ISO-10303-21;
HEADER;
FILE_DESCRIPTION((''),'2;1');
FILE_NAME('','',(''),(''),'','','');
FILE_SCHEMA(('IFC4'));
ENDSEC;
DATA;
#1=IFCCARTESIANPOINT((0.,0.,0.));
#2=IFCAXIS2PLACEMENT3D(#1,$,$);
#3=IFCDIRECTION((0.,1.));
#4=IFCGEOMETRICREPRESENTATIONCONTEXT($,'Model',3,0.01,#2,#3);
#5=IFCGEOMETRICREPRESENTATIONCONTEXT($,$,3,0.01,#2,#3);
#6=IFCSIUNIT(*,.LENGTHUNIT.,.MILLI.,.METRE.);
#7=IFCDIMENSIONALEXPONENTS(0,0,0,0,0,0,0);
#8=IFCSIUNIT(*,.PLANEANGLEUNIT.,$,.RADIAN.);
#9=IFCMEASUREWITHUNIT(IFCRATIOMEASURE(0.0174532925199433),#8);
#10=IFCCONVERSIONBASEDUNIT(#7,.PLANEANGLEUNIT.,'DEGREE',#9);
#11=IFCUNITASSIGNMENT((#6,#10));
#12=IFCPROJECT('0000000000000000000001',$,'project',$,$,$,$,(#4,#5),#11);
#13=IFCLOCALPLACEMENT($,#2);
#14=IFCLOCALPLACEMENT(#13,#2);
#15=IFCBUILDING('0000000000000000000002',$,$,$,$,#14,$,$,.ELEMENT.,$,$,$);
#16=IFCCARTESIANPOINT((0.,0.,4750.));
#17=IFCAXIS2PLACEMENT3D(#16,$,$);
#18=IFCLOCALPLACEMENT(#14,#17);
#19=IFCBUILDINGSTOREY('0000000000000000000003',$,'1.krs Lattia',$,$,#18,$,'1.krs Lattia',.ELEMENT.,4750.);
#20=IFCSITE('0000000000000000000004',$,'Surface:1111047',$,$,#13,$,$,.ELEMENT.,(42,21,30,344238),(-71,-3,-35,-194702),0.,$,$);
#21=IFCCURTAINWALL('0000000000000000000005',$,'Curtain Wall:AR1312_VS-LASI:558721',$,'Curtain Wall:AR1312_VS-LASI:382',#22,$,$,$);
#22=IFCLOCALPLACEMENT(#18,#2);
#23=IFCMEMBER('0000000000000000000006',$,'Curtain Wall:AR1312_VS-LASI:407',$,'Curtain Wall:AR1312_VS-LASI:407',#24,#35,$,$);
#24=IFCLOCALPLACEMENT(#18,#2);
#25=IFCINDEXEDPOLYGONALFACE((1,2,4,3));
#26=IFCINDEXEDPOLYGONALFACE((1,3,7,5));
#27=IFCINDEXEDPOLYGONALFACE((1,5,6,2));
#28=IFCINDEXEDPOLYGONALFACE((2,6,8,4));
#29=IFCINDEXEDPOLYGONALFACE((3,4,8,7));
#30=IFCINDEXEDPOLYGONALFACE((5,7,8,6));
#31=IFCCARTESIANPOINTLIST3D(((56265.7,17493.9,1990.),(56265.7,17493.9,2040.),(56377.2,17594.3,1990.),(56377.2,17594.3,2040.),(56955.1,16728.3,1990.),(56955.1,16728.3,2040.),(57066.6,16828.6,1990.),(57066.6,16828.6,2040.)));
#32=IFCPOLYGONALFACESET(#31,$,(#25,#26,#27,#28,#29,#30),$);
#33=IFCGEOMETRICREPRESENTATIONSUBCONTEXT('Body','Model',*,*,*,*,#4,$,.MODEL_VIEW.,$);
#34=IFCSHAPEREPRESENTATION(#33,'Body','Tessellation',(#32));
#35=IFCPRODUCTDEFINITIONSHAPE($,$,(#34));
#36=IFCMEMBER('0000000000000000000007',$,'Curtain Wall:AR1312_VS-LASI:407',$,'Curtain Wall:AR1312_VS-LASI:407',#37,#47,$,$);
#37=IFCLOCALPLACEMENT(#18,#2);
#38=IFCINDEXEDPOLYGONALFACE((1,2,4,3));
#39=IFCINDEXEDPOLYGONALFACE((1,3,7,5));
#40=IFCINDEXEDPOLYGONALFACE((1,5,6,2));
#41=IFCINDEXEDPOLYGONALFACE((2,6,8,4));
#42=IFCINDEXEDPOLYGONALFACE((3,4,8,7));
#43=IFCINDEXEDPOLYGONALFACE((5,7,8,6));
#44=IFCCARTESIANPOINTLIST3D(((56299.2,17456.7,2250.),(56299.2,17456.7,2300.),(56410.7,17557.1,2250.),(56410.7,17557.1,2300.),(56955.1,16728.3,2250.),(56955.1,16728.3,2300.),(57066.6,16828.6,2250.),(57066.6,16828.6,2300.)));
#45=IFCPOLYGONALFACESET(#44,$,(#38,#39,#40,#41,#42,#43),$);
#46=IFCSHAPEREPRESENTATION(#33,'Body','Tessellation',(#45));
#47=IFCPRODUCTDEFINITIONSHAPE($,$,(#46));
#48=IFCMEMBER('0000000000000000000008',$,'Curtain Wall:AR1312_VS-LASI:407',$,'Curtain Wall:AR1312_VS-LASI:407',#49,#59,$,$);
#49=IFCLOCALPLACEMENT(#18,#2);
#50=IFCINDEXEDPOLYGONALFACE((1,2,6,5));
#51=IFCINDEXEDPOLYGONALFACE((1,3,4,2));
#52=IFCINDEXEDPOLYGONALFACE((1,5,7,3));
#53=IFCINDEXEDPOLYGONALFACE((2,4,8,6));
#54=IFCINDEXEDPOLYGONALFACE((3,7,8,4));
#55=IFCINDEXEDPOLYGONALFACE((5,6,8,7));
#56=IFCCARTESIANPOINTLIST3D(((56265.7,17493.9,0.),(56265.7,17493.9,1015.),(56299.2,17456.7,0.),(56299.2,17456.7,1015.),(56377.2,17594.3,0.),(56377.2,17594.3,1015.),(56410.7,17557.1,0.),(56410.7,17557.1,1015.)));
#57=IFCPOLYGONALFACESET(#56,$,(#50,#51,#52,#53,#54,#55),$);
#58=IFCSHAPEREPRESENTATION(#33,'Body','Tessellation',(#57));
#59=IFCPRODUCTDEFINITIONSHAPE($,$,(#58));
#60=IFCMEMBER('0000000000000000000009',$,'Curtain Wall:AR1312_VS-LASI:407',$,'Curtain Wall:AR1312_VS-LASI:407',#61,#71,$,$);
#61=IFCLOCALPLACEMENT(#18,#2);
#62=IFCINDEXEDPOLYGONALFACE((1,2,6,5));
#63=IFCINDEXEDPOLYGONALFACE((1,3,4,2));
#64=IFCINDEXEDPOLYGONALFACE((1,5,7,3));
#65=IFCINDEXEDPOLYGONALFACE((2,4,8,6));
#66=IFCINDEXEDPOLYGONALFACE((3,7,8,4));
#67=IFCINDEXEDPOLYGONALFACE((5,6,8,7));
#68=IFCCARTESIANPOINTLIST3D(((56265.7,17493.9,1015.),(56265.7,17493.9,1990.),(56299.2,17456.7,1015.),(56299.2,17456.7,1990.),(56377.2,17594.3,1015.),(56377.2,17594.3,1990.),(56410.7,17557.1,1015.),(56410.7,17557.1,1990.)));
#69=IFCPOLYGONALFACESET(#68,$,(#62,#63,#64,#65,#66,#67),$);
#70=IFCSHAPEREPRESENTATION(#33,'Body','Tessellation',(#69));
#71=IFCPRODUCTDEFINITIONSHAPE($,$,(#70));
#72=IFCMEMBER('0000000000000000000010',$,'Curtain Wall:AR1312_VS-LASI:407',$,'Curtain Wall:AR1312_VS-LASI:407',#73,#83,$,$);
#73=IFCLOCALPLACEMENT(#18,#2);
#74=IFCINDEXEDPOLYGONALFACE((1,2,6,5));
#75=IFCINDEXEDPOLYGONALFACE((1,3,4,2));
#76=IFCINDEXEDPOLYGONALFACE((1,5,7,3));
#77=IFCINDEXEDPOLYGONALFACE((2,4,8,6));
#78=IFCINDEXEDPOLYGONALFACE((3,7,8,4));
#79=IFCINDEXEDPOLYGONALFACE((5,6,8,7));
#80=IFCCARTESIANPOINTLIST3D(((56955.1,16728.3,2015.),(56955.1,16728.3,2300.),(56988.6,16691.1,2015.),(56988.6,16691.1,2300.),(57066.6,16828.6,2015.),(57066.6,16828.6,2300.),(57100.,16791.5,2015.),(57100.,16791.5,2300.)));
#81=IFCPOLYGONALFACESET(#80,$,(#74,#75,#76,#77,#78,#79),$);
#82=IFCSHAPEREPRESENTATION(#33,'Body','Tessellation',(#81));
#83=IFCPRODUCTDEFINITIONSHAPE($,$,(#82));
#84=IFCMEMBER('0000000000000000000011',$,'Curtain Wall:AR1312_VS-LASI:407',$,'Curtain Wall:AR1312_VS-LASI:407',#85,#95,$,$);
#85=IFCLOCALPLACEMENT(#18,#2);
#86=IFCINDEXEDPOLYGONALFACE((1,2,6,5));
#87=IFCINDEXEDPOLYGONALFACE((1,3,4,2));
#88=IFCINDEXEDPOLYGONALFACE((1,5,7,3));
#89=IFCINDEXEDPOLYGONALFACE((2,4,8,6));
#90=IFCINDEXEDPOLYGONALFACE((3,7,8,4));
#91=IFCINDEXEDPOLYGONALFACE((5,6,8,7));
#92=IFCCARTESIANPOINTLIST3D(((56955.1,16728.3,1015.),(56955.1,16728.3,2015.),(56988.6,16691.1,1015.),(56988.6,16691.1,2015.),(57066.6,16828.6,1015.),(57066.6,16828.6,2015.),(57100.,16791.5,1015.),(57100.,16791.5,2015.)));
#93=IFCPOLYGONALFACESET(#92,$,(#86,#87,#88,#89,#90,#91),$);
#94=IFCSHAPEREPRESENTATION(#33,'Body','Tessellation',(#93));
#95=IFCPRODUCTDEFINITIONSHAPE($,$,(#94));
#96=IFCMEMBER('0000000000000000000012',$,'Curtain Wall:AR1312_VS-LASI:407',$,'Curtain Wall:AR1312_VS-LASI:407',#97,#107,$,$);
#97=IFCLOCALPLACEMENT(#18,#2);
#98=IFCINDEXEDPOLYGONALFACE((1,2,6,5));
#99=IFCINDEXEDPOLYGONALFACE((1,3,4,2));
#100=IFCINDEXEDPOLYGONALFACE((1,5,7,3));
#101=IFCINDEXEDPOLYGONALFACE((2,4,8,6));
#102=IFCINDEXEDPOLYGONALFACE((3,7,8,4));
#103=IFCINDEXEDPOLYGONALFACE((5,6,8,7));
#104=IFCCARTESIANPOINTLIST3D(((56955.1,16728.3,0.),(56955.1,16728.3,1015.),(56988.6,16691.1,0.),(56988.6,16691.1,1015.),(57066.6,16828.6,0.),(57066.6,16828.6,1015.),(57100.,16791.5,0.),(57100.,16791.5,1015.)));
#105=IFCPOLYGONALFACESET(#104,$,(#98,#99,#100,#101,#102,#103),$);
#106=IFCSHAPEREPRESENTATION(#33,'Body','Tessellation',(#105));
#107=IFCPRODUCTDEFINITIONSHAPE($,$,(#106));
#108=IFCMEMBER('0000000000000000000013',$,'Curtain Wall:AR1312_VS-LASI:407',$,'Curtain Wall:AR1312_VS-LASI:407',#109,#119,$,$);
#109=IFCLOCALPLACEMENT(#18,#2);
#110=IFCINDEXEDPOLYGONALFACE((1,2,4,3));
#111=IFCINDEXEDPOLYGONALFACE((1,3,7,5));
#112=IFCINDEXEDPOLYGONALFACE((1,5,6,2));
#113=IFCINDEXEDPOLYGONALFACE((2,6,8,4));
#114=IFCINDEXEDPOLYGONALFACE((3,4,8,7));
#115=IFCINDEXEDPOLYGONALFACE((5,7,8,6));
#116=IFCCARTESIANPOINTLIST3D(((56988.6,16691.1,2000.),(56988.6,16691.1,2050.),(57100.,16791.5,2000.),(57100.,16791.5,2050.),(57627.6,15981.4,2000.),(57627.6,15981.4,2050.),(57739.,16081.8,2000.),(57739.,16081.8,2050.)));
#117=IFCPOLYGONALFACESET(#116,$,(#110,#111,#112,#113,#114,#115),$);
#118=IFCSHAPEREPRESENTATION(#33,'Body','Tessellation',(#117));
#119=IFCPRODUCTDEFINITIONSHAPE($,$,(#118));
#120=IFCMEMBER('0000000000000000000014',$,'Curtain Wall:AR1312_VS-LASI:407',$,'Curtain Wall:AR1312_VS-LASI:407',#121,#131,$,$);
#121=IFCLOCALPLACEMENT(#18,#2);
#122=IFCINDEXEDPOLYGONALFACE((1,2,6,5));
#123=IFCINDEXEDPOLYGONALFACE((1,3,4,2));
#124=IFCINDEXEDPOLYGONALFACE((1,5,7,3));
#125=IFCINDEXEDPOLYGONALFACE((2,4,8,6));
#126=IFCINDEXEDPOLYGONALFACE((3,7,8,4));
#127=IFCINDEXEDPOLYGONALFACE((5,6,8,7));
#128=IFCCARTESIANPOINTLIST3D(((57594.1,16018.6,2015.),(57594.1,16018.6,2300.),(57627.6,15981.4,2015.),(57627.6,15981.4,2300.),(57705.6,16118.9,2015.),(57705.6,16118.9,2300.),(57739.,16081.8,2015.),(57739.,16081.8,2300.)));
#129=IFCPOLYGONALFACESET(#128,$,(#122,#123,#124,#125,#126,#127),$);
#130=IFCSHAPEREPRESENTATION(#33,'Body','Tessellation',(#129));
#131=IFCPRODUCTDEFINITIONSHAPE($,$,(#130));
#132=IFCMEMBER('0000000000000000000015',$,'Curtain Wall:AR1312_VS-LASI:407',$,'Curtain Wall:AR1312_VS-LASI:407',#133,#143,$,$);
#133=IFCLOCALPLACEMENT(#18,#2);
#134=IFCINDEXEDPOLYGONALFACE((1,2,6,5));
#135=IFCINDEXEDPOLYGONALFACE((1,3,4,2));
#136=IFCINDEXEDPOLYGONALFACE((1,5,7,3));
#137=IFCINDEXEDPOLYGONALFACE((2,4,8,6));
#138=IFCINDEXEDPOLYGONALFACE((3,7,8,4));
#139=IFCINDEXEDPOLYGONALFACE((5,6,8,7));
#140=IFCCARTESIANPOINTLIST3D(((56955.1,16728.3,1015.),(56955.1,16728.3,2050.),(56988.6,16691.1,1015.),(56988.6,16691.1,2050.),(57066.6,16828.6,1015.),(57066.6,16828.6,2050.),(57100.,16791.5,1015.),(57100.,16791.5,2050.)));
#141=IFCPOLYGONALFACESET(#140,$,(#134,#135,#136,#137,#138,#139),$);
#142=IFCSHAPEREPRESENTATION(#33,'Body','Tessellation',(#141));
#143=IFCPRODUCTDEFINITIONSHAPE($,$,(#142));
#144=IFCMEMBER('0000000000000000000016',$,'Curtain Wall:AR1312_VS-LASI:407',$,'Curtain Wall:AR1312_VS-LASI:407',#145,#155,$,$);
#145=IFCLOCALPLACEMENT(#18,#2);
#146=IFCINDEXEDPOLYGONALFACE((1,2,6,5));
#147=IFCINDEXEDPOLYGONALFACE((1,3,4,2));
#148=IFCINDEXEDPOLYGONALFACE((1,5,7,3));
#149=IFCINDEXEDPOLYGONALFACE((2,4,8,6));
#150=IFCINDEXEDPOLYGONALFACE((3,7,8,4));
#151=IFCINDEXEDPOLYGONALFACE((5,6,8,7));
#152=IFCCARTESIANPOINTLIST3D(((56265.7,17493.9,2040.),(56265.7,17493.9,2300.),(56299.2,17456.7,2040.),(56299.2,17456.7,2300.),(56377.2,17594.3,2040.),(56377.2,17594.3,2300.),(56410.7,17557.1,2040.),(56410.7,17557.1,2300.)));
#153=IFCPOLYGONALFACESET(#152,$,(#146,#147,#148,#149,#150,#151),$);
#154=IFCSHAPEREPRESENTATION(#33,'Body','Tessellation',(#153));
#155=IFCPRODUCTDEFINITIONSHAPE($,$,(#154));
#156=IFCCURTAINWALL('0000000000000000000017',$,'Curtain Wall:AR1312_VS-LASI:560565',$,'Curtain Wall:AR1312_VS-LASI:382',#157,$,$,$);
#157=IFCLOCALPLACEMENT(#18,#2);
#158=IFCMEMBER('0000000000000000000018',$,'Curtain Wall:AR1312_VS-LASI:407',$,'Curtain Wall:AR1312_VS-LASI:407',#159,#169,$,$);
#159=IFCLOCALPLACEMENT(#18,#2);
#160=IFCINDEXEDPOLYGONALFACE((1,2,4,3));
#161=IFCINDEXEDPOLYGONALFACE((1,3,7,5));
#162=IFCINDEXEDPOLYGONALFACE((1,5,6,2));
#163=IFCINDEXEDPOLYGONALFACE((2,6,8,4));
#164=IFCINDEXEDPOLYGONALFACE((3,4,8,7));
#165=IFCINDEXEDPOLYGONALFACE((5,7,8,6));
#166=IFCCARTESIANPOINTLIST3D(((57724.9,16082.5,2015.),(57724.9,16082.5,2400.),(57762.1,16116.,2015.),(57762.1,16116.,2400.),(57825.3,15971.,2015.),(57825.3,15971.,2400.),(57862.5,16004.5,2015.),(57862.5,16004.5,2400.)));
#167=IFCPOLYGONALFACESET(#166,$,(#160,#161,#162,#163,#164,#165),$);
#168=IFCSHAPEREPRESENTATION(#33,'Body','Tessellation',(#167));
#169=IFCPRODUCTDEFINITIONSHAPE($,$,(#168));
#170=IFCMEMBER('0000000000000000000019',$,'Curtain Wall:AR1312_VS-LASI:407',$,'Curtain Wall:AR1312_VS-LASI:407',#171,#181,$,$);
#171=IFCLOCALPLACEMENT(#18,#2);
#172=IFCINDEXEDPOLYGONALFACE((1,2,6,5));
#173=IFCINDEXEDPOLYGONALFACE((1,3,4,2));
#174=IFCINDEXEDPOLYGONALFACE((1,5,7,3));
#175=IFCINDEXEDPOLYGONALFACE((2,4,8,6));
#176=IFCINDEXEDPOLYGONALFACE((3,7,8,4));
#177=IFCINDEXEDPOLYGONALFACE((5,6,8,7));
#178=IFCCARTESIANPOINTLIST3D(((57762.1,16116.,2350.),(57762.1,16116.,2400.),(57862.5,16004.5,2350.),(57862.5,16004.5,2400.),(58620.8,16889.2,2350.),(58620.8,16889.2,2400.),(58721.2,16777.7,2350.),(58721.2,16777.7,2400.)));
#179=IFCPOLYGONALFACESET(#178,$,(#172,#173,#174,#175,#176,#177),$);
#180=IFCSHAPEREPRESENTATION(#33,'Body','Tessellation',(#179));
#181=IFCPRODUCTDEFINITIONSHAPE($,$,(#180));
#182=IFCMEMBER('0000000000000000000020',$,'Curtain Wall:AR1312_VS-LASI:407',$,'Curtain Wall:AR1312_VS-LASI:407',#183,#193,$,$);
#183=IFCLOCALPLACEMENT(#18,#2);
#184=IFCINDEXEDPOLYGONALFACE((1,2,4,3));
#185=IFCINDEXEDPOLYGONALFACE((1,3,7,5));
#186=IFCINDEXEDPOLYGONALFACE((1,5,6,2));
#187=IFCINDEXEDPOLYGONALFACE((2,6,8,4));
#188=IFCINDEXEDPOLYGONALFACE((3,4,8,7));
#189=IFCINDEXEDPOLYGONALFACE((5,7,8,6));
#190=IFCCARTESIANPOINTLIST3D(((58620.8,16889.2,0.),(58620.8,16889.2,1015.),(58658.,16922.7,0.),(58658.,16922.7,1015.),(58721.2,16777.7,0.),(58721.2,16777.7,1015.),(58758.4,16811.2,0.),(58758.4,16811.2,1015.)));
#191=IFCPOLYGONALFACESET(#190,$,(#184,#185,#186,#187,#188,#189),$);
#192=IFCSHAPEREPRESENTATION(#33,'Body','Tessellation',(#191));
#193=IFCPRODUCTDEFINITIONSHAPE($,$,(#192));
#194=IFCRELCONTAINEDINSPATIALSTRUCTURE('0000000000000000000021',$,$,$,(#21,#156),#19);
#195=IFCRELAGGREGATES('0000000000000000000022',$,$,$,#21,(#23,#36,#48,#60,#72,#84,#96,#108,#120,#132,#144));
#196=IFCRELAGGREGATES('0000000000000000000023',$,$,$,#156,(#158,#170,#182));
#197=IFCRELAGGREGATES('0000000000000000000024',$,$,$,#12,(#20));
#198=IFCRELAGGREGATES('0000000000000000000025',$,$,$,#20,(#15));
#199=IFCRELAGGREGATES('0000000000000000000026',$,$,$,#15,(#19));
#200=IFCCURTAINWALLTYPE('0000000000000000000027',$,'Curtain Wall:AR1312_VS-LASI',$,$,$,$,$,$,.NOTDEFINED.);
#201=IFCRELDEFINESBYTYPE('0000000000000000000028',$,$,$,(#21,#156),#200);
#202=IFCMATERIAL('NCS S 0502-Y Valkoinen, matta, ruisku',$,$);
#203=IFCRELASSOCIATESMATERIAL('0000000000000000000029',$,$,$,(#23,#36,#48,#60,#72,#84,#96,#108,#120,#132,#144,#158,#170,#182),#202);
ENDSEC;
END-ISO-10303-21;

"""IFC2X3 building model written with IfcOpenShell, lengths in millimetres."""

from ifc_helpers import new_model, entity, si_unit, converted_unit, direction, frame, frame_2d, origin, origin_2d_with_axis, place, context, subcontext, project, spatial, rectangle, extrude, material, type_object, element, aggregate, save


model = new_model("IFC2X3")

# Units and contexts
model_context = context("Model", 3, precision=0.01, world=origin(), true_north=direction((0.0, 1.0)))
context_of_model = context(None, 3, precision=0.01, world=origin(), true_north=direction((0.0, 1.0)))
body_context = subcontext(model_context, "Body", "Model", "MODEL_VIEW")
ifc_project = project(units=[si_unit("LENGTHUNIT", "METRE", prefix="MILLI"), converted_unit("PLANEANGLEUNIT", "DEGREE", entity("IfcRatioMeasure", 0.0174532925199433), si_unit("PLANEANGLEUNIT", "RADIAN"), dimensions=[0, 0, 0, 0, 0, 0, 0])], contexts=[model_context, context_of_model])

# Site, building, storey
site_placement = place(None, origin())
site = spatial("IfcSite", under=ifc_project, at=site_placement, Name="Surface:1111047", CompositionType="ELEMENT", RefLatitude=(42, 21, 30, 344238), RefLongitude=(-71, -3, -35, -194702), RefElevation=0.0)
building_placement = place(site_placement, origin())
building = spatial("IfcBuilding", under=site, at=building_placement, CompositionType="ELEMENT")
storey_placement = place(building_placement, frame((0.0, 0.0, 4750.0)))
storey = spatial("IfcBuildingStorey", under=building, at=storey_placement, Name="1.krs Lattia", LongName="1.krs Lattia", CompositionType="ELEMENT", Elevation=4750.0)

# Shared definitions
curtain_wall_type = type_object("IfcCurtainWallType", Name="Curtain Wall:AR1312_VS-LASI", PredefinedType="NOTDEFINED")
ifc_material = material(Name="NCS S 0502-Y Valkoinen, matta, ruisku")

# Curtain walls, members
curtain_wall_1_placement = place(storey_placement, frame((0.0, 0.0, -4750.0)))
curtain_wall_1 = element("IfcCurtainWall", 1, at=curtain_wall_1_placement, inside=storey, type_object=curtain_wall_type, Name="Curtain Wall:AR1312_VS-LASI:558721", ObjectType="Curtain Wall:AR1312_VS-LASI:382")
member_1_placement = place(curtain_wall_1_placement, frame((0.0, 0.0, 4750.0)))
member_1 = element("IfcMember", 2, at=member_1_placement, material=ifc_material, Name="Curtain Wall:AR1312_VS-LASI:407", ObjectType="Curtain Wall:AR1312_VS-LASI:407", context=body_context, shape_type="SweptSolid", body=[
    extrude(rectangle(XDim=50.0, YDim=150.0, at=frame_2d((0.0, 0.0), x_axis=(1.0, 0.0))), frame((57010.8, 16778.4, 2015.0), z_axis=(-0.669131, 0.743145, 0.0), x_axis=(0.0, 0.0, -1.0)), (0.0, 0.0, 1.0), 1030.3),
])
member_2_placement = place(curtain_wall_1_placement, frame((0.0, 0.0, 4750.0)))
member_2 = element("IfcMember", 3, at=member_2_placement, material=ifc_material, Name="Curtain Wall:AR1312_VS-LASI:407", ObjectType="Curtain Wall:AR1312_VS-LASI:407", context=body_context, shape_type="SweptSolid", body=[
    extrude(rectangle(XDim=50.0, YDim=150.0, at=origin_2d_with_axis()), frame((57010.8, 16778.4, 2275.0), z_axis=(-0.669131, 0.743145, 0.0), x_axis=(0.0, 0.0, -1.0)), (0.0, 0.0, 1.0), 980.3),
])
member_3_placement = place(curtain_wall_1_placement, frame((0.0, 0.0, 4750.0)))
member_3 = element("IfcMember", 4, at=member_3_placement, material=ifc_material, Name="Curtain Wall:AR1312_VS-LASI:407", ObjectType="Curtain Wall:AR1312_VS-LASI:407", context=body_context, shape_type="SweptSolid", body=[
    extrude(rectangle(XDim=150.0, YDim=50.0, at=frame_2d((0.0, 0.0), x_axis=(1.0, 0.0))), frame((56338.2, 17525.5, 1015.0), z_axis=(0.0, 0.0, -1.0), x_axis=(0.743145, 0.669131, 0.0)), (0.0, 0.0, 1.0), 1015.0),
])
member_4_placement = place(curtain_wall_1_placement, frame((0.0, 0.0, 4750.0)))
member_4 = element("IfcMember", 5, at=member_4_placement, material=ifc_material, Name="Curtain Wall:AR1312_VS-LASI:407", ObjectType="Curtain Wall:AR1312_VS-LASI:407", context=body_context, shape_type="SweptSolid", body=[
    extrude(rectangle(XDim=150.0, YDim=50.0, at=frame_2d((0.0, 0.0), x_axis=(1.0, 0.0))), frame((56338.2, 17525.5, 1990.0), z_axis=(0.0, 0.0, -1.0), x_axis=(0.743145, 0.669131, 0.0)), (0.0, 0.0, 1.0), 975.0),
])
member_5_placement = place(curtain_wall_1_placement, frame((0.0, 0.0, 4750.0)))
member_5 = element("IfcMember", 6, at=member_5_placement, material=ifc_material, Name="Curtain Wall:AR1312_VS-LASI:407", ObjectType="Curtain Wall:AR1312_VS-LASI:407", context=body_context, shape_type="SweptSolid", body=[
    extrude(rectangle(XDim=50.0, YDim=150.0, at=origin_2d_with_axis()), frame((57027.6, 16759.9, 2015.0), z_axis=(0.0, 0.0, 1.0), x_axis=(0.669131, -0.743145, 0.0)), (0.0, 0.0, 1.0), 285.0),
])
member_6_placement = place(curtain_wall_1_placement, frame((0.0, 0.0, 4750.0)))
member_6 = element("IfcMember", 7, at=member_6_placement, material=ifc_material, Name="Curtain Wall:AR1312_VS-LASI:407", ObjectType="Curtain Wall:AR1312_VS-LASI:407", context=body_context, shape_type="SweptSolid", body=[
    extrude(rectangle(XDim=50.0, YDim=150.0, at=origin_2d_with_axis()), frame((57027.6, 16759.9, 1015.0), z_axis=(0.0, 0.0, 1.0), x_axis=(0.669131, -0.743145, 0.0)), (0.0, 0.0, 1.0), 1000.0),
])
member_7_placement = place(curtain_wall_1_placement, frame((0.0, 0.0, 4750.0)))
member_7 = element("IfcMember", 8, at=member_7_placement, material=ifc_material, Name="Curtain Wall:AR1312_VS-LASI:407", ObjectType="Curtain Wall:AR1312_VS-LASI:407", context=body_context, shape_type="SweptSolid", body=[
    extrude(rectangle(XDim=50.0, YDim=150.0, at=frame_2d((0.0, 0.0), x_axis=(1.0, 0.0))), frame((57027.6, 16759.9, 0.0), z_axis=(0.0, 0.0, 1.0), x_axis=(0.669131, -0.743145, 0.0)), (0.0, 0.0, 1.0), 1015.0),
])
member_8_placement = place(curtain_wall_1_placement, frame((0.0, 0.0, 4750.0)))
member_8 = element("IfcMember", 9, at=member_8_placement, material=ifc_material, Name="Curtain Wall:AR1312_VS-LASI:407", ObjectType="Curtain Wall:AR1312_VS-LASI:407", context=body_context, shape_type="SweptSolid", body=[
    extrude(rectangle(XDim=50.0, YDim=150.0, at=frame_2d((0.0, 0.0), x_axis=(1.0, 0.0))), frame((57044.3, 16741.3, 2025.0), z_axis=(0.669131, -0.743145, 0.0), x_axis=(0.0, 0.0, -1.0)), (0.0, 0.0, 1.0), 955.0),
])
member_9_placement = place(curtain_wall_1_placement, frame((0.0, 0.0, 4750.0)))
member_9 = element("IfcMember", 10, at=member_9_placement, material=ifc_material, Name="Curtain Wall:AR1312_VS-LASI:407", ObjectType="Curtain Wall:AR1312_VS-LASI:407", context=body_context, shape_type="SweptSolid", body=[
    extrude(rectangle(XDim=50.0, YDim=150.0, at=frame_2d((0.0, 0.0), x_axis=(1.0, 0.0))), frame((57666.6, 16050.2, 2015.0), z_axis=(0.0, 0.0, 1.0), x_axis=(0.669131, -0.743145, 0.0)), (0.0, 0.0, 1.0), 285.0),
])
member_10_placement = place(curtain_wall_1_placement, frame((0.0, 0.0, 4750.0)))
member_10 = element("IfcMember", 11, at=member_10_placement, material=ifc_material, Name="Curtain Wall:AR1312_VS-LASI:407", ObjectType="Curtain Wall:AR1312_VS-LASI:407", context=body_context, shape_type="SweptSolid", body=[
    extrude(rectangle(XDim=50.0, YDim=150.0, at=frame_2d((0.0, 0.0), x_axis=(1.0, 0.0))), frame((57027.6, 16759.9, 1015.0), z_axis=(0.0, 0.0, 1.0), x_axis=(0.669131, -0.743145, 0.0)), (0.0, 0.0, 1.0), 1035.0),
])
member_11_placement = place(curtain_wall_1_placement, frame((0.0, 0.0, 4750.0)))
member_11 = element("IfcMember", 12, at=member_11_placement, material=ifc_material, Name="Curtain Wall:AR1312_VS-LASI:407", ObjectType="Curtain Wall:AR1312_VS-LASI:407", context=body_context, shape_type="SweptSolid", body=[
    extrude(rectangle(XDim=150.0, YDim=50.0, at=frame_2d((0.0, 0.0), x_axis=(1.0, 0.0))), frame((56338.2, 17525.5, 2300.0), z_axis=(0.0, 0.0, -1.0), x_axis=(0.743145, 0.669131, 0.0)), (0.0, 0.0, 1.0), 260.0),
])
aggregate(curtain_wall_1, [member_1, member_2, member_3, member_4, member_5, member_6, member_7, member_8, member_9, member_10, member_11])
curtain_wall_2_placement = place(storey_placement, frame((0.0, 0.0, -4750.0)))
curtain_wall_2 = element("IfcCurtainWall", 13, at=curtain_wall_2_placement, inside=storey, type_object=curtain_wall_type, Name="Curtain Wall:AR1312_VS-LASI:560565", ObjectType="Curtain Wall:AR1312_VS-LASI:382")
member_12_placement = place(curtain_wall_2_placement, frame((0.0, 0.0, 4750.0)))
member_12 = element("IfcMember", 14, at=member_12_placement, material=ifc_material, Name="Curtain Wall:AR1312_VS-LASI:407", ObjectType="Curtain Wall:AR1312_VS-LASI:407", context=body_context, shape_type="SweptSolid", body=[
    extrude(rectangle(XDim=150.0, YDim=50.0, at=frame_2d((0.0, 0.0), x_axis=(1.0, 0.0))), frame((57793.7, 16043.5, 2400.0), z_axis=(0.0, 0.0, -1.0), x_axis=(0.669131, -0.743145, 0.0)), (0.0, 0.0, 1.0), 385.0),
])
member_13_placement = place(curtain_wall_2_placement, frame((0.0, 0.0, 4750.0)))
member_13 = element("IfcMember", 15, at=member_13_placement, material=ifc_material, Name="Curtain Wall:AR1312_VS-LASI:407", ObjectType="Curtain Wall:AR1312_VS-LASI:407", context=body_context, shape_type="SweptSolid", body=[
    extrude(rectangle(XDim=50.0, YDim=150.0, at=frame_2d((0.0, 0.0), x_axis=(1.0, 0.0))), frame((58671.0, 16833.5, 2375.0), z_axis=(-0.743145, -0.669131, 0.0), x_axis=(0.0, 0.0, -1.0)), (0.0, 0.0, 1.0), 1155.6),
])
member_14_placement = place(curtain_wall_2_placement, frame((0.0, 0.0, 4750.0)))
member_14 = element("IfcMember", 16, at=member_14_placement, material=ifc_material, Name="Curtain Wall:AR1312_VS-LASI:407", ObjectType="Curtain Wall:AR1312_VS-LASI:407", context=body_context, shape_type="SweptSolid", body=[
    extrude(rectangle(XDim=50.0, YDim=150.0, at=frame_2d((0.0, 0.0), x_axis=(1.0, 0.0))), frame((58689.6, 16850.2, 0.0), z_axis=(0.0, 0.0, 1.0), x_axis=(0.743145, 0.669131, 0.0)), (0.0, 0.0, 1.0), 1015.0),
])
aggregate(curtain_wall_2, [member_12, member_13, member_14])

save(model, "model.ifc")
